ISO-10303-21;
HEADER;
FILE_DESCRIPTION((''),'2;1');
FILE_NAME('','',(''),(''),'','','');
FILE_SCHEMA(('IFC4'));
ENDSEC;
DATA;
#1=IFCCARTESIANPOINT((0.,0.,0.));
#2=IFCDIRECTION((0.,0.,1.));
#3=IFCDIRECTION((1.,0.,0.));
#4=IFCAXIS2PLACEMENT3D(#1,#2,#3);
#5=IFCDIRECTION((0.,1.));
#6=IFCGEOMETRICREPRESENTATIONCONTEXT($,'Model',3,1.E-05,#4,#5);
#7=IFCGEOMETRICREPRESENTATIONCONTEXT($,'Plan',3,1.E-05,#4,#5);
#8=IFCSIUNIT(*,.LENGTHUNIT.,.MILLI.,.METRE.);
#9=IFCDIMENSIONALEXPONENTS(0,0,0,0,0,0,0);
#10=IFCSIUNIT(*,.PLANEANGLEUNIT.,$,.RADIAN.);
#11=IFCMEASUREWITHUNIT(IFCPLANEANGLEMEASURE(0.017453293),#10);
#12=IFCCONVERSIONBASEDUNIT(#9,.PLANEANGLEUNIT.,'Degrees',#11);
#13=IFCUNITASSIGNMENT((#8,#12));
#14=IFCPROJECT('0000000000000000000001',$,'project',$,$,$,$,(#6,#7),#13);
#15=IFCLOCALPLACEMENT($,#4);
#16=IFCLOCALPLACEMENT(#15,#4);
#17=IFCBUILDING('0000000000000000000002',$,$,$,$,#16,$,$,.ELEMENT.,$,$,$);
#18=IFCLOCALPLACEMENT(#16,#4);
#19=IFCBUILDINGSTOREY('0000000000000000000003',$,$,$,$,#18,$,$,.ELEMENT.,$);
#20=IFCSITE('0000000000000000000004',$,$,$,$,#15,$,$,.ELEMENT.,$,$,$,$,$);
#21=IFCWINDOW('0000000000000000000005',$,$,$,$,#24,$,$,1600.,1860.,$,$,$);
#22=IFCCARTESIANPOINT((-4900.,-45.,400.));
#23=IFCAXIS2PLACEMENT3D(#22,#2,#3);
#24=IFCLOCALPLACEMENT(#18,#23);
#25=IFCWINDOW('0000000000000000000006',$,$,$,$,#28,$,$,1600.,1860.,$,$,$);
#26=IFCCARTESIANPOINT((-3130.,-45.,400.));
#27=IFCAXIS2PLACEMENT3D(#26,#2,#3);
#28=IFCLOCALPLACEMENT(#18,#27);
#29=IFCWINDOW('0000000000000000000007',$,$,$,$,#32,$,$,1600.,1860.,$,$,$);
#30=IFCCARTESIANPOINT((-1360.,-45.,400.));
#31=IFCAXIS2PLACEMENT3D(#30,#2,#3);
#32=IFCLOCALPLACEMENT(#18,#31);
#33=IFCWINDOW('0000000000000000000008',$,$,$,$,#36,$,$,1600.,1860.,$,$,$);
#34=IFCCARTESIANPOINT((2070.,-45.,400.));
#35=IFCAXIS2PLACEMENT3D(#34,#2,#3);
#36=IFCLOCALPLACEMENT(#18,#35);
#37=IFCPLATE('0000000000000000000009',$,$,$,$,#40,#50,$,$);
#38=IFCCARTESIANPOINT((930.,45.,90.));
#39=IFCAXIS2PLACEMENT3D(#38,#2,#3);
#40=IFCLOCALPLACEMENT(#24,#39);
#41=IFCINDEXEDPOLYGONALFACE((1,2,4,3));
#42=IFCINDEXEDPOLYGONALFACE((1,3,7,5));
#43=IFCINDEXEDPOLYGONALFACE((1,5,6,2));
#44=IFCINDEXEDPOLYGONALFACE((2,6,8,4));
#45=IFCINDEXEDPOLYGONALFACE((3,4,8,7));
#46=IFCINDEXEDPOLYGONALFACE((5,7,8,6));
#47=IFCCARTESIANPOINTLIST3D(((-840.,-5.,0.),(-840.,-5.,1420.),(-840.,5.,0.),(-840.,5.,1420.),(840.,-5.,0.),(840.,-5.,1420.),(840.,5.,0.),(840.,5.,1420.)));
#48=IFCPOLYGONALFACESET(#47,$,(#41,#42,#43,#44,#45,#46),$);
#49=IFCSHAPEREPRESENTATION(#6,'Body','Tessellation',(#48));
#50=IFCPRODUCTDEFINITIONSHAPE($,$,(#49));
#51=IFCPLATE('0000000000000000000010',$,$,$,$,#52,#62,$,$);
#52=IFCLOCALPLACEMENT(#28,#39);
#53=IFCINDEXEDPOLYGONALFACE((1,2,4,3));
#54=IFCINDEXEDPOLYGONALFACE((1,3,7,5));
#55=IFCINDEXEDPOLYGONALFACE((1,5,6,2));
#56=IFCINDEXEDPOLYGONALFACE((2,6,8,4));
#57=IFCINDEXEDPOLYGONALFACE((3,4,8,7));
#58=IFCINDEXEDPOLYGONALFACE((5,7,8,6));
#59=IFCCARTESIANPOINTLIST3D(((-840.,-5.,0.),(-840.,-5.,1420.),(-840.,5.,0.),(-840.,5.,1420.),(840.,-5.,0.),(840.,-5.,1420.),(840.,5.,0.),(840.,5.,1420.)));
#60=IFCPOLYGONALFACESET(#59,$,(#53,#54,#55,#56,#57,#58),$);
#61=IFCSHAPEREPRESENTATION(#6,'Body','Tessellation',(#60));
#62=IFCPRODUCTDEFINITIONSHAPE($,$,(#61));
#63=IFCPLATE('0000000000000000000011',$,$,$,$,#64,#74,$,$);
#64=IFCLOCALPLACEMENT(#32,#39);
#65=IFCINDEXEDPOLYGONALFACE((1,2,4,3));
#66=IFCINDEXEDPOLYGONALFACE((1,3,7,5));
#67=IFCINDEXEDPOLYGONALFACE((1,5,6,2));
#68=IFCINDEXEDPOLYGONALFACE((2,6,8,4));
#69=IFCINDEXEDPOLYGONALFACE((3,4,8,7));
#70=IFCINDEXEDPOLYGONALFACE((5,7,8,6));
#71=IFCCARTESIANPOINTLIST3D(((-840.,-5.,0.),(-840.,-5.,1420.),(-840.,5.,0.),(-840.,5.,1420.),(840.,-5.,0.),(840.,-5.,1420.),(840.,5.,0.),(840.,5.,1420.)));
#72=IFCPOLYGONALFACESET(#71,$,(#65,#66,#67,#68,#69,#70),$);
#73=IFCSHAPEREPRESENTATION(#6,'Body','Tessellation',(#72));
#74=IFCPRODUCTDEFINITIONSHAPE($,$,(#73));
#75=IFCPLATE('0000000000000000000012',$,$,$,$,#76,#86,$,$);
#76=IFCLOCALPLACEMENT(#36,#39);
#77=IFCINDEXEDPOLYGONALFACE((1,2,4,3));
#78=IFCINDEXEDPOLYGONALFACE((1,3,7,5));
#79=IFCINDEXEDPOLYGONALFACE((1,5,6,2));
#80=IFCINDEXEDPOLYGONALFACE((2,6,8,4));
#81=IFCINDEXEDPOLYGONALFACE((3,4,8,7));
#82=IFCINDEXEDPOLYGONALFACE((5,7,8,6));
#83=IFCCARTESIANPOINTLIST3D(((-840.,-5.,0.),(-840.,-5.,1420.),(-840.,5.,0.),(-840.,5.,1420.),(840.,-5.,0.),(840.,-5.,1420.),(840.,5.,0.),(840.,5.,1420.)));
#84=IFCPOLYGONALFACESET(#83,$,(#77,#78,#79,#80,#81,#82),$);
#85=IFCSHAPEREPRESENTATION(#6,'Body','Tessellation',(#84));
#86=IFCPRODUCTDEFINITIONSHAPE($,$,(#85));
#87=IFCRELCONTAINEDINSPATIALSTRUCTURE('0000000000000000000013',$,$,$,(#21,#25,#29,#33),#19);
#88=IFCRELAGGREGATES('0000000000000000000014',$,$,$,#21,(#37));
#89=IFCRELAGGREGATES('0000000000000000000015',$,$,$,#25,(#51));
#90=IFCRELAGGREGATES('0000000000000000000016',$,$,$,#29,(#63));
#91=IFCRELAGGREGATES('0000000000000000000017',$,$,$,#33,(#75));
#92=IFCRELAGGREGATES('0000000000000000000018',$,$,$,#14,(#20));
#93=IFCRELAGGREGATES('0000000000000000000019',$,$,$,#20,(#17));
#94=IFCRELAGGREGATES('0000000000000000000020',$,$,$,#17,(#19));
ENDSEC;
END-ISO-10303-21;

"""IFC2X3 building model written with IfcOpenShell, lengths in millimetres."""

from ifc_helpers import new_model, entity, si_unit, converted_unit, direction, frame, origin_with_axes, place, context, project, spatial, polyline, outline, extrude, element, aggregate, save


model = new_model("IFC2X3")

# Units and contexts
model_context = context("Model", 3, precision=1e-05, world=origin_with_axes(), true_north=direction((0.0, 1.0)))
plan_context = context("Plan", 3, precision=1e-05, world=origin_with_axes(), true_north=direction((0.0, 1.0)))
ifc_project = project(units=[si_unit("LENGTHUNIT", "METRE", prefix="MILLI"), converted_unit("PLANEANGLEUNIT", "Degrees", entity("IfcPlaneAngleMeasure", 0.017453293), si_unit("PLANEANGLEUNIT", "RADIAN"), dimensions=[0, 0, 0, 0, 0, 0, 0])], contexts=[model_context, plan_context])

# Site, building, storey
site_placement = place(None, origin_with_axes())
site = spatial("IfcSite", under=ifc_project, at=site_placement, CompositionType="ELEMENT")
building_placement = place(site_placement, origin_with_axes())
building = spatial("IfcBuilding", under=site, at=building_placement, CompositionType="ELEMENT")
storey_placement = place(building_placement, origin_with_axes())
storey = spatial("IfcBuildingStorey", under=building, at=storey_placement, CompositionType="ELEMENT")

# Windows
window_1_placement = place(storey_placement, frame((-4900.0, -45.0, 400.0), z_axis=(0.0, 0.0, 1.0), x_axis=(1.0, 0.0, 0.0)))
window_1 = element("IfcWindow", 1, at=window_1_placement, inside=storey, OverallHeight=1600.0, OverallWidth=1860.0)
window_2_placement = place(storey_placement, frame((-3130.0, -45.0, 400.0), z_axis=(0.0, 0.0, 1.0), x_axis=(1.0, 0.0, 0.0)))
window_2 = element("IfcWindow", 2, at=window_2_placement, inside=storey, OverallHeight=1600.0, OverallWidth=1860.0)
window_3_placement = place(storey_placement, frame((-1360.0, -45.0, 400.0), z_axis=(0.0, 0.0, 1.0), x_axis=(1.0, 0.0, 0.0)))
window_3 = element("IfcWindow", 3, at=window_3_placement, inside=storey, OverallHeight=1600.0, OverallWidth=1860.0)
window_4_placement = place(storey_placement, frame((2070.0, -45.0, 400.0), z_axis=(0.0, 0.0, 1.0), x_axis=(1.0, 0.0, 0.0)))
window_4 = element("IfcWindow", 4, at=window_4_placement, inside=storey, OverallHeight=1600.0, OverallWidth=1860.0)

# Plates
plate_1_placement = place(window_1_placement, frame((930.0, 45.0, 90.0), z_axis=(0.0, 0.0, 1.0), x_axis=(1.0, 0.0, 0.0)))
plate_1 = element("IfcPlate", 5, at=plate_1_placement, context=model_context, shape_type="SweptSolid", body=[
    extrude(outline(polyline([(-840.0, -5.0), (840.0, -5.0), (840.0, 5.0), (-840.0, 5.0), (-840.0, -5.0)])), origin_with_axes(), (0.0, 0.0, 1.0), 1420.0),
])
aggregate(window_1, [plate_1])
plate_2_placement = place(window_2_placement, frame((930.0, 45.0, 90.0), z_axis=(0.0, 0.0, 1.0), x_axis=(1.0, 0.0, 0.0)))
plate_2 = element("IfcPlate", 6, at=plate_2_placement, context=model_context, shape_type="SweptSolid", body=[
    extrude(outline(polyline([(-840.0, -5.0), (840.0, -5.0), (840.0, 5.0), (-840.0, 5.0), (-840.0, -5.0)])), origin_with_axes(), (0.0, 0.0, 1.0), 1420.0),
])
aggregate(window_2, [plate_2])
plate_3_placement = place(window_3_placement, frame((930.0, 45.0, 90.0), z_axis=(0.0, 0.0, 1.0), x_axis=(1.0, 0.0, 0.0)))
plate_3 = element("IfcPlate", 7, at=plate_3_placement, context=model_context, shape_type="SweptSolid", body=[
    extrude(outline(polyline([(-840.0, -5.0), (840.0, -5.0), (840.0, 5.0), (-840.0, 5.0), (-840.0, -5.0)])), origin_with_axes(), (0.0, 0.0, 1.0), 1420.0),
])
aggregate(window_3, [plate_3])
plate_4_placement = place(window_4_placement, frame((930.0, 45.0, 90.0), z_axis=(0.0, 0.0, 1.0), x_axis=(1.0, 0.0, 0.0)))
plate_4 = element("IfcPlate", 8, at=plate_4_placement, context=model_context, shape_type="SweptSolid", body=[
    extrude(outline(polyline([(-840.0, -5.0), (840.0, -5.0), (840.0, 5.0), (-840.0, 5.0), (-840.0, -5.0)])), origin_with_axes(), (0.0, 0.0, 1.0), 1420.0),
])
aggregate(window_4, [plate_4])

save(model, "model.ifc")
